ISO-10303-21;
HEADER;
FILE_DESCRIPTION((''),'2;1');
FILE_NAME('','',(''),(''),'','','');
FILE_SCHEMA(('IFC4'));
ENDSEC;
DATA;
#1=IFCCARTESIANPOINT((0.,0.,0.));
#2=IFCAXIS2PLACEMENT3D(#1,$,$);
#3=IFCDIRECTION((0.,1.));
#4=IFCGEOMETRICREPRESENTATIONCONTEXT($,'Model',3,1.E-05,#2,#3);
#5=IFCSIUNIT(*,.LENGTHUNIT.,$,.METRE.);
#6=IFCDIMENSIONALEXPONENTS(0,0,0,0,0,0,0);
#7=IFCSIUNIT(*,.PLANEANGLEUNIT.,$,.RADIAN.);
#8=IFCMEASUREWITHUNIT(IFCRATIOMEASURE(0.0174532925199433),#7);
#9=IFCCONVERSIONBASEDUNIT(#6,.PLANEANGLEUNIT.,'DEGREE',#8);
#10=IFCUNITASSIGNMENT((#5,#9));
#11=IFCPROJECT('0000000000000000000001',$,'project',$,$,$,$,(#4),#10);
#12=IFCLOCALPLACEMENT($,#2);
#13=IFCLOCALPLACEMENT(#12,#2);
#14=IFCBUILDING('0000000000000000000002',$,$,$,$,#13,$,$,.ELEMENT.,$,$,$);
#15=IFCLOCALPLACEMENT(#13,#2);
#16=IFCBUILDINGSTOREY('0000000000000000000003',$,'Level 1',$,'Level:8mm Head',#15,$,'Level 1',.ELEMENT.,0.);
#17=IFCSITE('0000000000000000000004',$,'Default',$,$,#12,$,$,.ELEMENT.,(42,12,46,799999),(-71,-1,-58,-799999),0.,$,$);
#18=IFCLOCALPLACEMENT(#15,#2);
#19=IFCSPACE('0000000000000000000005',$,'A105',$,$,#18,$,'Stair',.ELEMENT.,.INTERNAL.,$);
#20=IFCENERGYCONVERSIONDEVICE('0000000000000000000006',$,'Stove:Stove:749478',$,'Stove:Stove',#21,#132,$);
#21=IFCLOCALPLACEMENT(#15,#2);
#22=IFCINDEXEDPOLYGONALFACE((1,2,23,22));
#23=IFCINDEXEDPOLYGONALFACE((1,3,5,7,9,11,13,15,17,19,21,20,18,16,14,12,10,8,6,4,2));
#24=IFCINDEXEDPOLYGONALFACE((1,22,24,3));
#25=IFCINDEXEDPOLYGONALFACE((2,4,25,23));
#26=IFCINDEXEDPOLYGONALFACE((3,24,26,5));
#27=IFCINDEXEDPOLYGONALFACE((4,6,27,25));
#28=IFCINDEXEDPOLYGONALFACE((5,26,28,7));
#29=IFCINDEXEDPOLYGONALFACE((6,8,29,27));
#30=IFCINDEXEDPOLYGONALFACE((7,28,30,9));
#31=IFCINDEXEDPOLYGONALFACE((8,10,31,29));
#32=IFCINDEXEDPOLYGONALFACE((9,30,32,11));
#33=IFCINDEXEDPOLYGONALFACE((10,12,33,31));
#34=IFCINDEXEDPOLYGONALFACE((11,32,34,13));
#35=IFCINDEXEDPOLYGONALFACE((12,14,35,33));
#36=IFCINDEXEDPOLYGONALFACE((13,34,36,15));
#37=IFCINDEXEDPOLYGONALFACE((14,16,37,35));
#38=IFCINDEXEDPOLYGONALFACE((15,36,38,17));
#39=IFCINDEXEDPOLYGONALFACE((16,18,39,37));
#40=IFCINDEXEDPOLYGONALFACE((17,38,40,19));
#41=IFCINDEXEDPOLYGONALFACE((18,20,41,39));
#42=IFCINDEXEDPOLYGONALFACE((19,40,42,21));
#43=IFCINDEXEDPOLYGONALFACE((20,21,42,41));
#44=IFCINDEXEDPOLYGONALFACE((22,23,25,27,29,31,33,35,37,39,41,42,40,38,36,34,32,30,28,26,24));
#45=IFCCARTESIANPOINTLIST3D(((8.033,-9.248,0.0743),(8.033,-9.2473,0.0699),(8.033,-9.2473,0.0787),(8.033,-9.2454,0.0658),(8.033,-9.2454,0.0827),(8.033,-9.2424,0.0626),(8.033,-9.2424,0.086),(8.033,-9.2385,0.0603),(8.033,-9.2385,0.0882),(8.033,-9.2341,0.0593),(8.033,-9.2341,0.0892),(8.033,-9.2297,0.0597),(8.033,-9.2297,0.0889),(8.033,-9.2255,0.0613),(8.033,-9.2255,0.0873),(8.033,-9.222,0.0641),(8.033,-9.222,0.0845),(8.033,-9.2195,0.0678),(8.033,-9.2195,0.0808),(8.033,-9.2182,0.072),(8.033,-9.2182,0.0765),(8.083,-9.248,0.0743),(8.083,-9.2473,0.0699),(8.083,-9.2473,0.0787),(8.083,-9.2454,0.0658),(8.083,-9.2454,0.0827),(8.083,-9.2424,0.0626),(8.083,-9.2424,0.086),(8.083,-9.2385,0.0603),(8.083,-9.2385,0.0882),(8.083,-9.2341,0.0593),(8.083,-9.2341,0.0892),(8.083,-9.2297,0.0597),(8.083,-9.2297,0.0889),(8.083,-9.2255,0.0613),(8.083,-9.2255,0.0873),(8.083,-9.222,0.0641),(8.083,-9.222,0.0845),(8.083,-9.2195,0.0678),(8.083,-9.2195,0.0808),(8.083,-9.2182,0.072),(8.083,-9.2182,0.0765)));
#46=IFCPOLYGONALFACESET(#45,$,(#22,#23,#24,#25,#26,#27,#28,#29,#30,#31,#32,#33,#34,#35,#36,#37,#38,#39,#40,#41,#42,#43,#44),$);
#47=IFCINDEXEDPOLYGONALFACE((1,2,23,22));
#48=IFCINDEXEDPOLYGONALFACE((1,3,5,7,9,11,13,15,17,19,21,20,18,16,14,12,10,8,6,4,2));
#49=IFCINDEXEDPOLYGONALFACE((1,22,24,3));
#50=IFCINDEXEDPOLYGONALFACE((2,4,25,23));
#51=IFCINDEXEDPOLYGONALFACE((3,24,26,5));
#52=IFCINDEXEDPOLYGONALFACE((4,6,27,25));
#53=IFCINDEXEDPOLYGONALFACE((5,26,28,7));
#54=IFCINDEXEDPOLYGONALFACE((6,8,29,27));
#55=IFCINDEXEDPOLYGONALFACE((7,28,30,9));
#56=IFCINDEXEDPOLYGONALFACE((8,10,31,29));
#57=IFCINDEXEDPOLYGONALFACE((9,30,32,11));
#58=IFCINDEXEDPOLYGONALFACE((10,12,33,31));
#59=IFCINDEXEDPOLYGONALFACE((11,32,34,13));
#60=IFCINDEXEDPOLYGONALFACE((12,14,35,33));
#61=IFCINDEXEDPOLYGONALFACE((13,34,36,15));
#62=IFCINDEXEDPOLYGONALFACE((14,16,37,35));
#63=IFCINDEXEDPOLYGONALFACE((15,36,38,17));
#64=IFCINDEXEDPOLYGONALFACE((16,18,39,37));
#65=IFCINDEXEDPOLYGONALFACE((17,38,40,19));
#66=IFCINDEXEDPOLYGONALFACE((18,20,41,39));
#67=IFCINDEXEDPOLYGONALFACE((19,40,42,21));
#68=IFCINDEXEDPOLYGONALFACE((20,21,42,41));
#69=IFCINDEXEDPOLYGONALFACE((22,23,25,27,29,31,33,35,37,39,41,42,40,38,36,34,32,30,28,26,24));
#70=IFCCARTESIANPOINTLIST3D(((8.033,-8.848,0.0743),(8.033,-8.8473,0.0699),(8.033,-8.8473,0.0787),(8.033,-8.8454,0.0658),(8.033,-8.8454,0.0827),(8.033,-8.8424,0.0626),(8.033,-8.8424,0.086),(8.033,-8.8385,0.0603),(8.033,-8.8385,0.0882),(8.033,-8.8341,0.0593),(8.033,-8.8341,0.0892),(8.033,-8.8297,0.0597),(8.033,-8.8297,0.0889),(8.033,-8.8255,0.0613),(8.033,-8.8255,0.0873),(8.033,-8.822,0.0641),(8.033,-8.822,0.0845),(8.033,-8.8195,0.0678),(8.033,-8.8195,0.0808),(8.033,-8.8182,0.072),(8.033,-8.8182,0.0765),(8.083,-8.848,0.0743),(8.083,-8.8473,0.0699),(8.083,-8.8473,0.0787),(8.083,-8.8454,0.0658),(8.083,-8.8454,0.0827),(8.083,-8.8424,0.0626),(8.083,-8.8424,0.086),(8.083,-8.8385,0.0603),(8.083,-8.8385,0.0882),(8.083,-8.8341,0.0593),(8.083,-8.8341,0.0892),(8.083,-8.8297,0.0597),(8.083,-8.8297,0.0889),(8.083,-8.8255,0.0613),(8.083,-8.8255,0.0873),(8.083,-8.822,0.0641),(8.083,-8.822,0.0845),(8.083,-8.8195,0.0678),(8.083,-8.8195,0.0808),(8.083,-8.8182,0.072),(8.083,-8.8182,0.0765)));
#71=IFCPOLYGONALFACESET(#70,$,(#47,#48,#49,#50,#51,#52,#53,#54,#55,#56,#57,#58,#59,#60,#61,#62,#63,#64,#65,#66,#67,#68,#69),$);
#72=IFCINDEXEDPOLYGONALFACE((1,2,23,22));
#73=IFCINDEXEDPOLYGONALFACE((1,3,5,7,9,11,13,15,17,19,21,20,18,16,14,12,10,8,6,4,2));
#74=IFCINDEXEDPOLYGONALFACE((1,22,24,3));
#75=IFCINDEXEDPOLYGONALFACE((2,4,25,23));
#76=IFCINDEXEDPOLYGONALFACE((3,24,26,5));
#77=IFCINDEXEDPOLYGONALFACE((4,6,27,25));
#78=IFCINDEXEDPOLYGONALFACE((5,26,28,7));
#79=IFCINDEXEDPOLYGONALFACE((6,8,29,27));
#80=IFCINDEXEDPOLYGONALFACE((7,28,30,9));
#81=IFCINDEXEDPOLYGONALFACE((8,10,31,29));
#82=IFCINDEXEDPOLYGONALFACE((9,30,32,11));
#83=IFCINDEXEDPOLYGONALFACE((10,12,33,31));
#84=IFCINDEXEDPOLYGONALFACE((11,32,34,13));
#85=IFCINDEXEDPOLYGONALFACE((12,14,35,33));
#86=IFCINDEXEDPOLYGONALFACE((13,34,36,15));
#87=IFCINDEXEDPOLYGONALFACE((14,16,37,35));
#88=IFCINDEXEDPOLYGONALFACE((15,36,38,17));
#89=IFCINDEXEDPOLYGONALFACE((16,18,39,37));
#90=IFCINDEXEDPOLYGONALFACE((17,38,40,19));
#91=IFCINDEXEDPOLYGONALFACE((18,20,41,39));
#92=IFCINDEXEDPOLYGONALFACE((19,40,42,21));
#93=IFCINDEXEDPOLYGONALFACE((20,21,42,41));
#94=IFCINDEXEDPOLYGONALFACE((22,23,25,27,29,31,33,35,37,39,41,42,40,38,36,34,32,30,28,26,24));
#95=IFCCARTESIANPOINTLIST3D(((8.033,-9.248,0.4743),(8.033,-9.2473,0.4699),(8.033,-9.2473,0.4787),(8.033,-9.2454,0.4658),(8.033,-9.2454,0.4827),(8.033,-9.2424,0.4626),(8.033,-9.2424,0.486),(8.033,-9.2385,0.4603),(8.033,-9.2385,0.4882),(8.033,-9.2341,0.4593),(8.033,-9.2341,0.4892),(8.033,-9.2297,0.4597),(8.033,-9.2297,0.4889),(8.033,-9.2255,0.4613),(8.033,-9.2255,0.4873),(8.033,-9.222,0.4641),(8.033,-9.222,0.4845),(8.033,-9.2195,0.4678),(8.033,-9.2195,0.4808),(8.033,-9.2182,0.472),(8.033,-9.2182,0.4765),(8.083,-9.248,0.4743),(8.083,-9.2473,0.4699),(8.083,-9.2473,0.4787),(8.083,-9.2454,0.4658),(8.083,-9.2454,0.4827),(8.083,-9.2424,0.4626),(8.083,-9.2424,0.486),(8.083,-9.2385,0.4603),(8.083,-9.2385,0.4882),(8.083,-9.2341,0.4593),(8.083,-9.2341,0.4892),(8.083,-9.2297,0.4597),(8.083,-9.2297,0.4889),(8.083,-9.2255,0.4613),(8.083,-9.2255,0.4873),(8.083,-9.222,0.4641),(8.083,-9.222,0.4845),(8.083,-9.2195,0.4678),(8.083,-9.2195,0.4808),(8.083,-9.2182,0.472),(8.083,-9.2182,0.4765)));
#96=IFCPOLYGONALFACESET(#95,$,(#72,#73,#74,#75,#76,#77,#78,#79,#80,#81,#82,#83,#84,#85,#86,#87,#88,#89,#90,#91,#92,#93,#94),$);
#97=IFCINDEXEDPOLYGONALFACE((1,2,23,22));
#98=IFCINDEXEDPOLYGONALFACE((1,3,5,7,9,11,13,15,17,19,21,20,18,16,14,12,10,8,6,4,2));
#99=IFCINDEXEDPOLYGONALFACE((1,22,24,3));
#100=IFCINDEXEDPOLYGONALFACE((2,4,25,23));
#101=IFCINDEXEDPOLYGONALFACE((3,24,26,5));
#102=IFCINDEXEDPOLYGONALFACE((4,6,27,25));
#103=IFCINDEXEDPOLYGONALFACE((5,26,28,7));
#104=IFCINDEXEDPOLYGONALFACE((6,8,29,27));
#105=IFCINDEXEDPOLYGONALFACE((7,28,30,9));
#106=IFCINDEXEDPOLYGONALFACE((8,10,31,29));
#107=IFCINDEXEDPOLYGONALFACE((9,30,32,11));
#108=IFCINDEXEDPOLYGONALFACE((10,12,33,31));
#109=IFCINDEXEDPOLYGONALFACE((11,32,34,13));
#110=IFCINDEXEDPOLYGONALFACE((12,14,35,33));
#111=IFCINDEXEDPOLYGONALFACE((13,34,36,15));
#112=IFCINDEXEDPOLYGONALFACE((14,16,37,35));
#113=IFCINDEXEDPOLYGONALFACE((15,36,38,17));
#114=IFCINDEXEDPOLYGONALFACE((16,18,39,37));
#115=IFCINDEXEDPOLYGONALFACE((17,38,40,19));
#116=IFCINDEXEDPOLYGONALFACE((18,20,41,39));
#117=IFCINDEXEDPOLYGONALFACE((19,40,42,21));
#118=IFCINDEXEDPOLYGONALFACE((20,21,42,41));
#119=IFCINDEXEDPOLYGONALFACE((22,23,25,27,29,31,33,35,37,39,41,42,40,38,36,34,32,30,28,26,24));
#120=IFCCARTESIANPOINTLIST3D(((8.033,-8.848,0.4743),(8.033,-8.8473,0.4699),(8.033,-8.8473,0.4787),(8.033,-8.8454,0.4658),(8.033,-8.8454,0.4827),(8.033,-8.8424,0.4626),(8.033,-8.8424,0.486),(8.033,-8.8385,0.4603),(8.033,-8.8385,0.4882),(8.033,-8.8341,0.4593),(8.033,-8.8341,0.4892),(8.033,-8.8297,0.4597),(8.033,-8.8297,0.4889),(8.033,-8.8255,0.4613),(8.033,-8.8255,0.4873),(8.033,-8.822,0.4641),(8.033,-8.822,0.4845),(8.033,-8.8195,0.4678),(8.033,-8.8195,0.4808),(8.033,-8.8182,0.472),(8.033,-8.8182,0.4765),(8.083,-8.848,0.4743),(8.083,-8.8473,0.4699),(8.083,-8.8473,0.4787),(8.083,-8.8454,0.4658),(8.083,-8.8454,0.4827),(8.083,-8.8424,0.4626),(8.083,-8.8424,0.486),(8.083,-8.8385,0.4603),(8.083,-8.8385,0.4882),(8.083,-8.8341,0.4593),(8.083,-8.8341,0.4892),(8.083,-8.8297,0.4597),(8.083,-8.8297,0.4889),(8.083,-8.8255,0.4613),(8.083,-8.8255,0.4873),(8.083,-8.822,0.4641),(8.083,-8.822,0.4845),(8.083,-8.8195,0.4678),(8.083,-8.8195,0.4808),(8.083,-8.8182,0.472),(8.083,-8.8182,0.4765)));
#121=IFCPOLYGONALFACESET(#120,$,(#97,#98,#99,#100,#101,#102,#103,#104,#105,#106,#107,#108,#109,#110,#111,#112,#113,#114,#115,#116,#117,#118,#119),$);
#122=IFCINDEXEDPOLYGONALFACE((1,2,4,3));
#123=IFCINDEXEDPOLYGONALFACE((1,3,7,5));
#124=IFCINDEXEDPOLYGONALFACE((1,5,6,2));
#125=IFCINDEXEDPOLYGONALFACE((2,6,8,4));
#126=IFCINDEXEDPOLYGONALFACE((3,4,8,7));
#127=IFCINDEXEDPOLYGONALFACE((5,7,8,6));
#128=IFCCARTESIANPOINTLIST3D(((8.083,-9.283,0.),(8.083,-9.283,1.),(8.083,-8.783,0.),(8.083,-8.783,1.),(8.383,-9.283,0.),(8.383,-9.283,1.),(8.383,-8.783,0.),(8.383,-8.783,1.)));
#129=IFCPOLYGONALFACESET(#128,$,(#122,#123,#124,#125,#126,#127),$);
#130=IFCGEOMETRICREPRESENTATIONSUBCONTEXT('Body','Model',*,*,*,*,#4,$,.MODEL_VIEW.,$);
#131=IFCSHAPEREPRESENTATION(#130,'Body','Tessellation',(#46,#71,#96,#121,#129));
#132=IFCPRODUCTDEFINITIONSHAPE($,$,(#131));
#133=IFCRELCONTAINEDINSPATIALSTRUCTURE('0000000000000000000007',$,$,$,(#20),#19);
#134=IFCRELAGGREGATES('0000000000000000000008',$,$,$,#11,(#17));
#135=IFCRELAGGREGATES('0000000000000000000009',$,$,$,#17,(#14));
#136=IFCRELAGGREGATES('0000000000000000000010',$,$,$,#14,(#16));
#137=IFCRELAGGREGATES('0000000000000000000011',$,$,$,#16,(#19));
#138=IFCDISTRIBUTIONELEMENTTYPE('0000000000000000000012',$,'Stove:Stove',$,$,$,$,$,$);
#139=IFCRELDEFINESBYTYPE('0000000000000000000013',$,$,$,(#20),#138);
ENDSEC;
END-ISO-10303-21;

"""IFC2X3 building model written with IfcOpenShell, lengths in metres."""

from ifc_helpers import new_model, entity, si_unit, converted_unit, direction, frame, frame_2d, origin, origin_2d_with_axis, place, context, subcontext, project, spatial, rectangle, circle, extrude, source, transform, mapped, type_object, type_shapes, element, save


model = new_model("IFC2X3")

# Units and contexts
model_context = context("Model", 3, precision=1e-05, world=origin(), true_north=direction((0.0, 1.0)))
body_context = subcontext(model_context, "Body", "Model", "MODEL_VIEW")
ifc_project = project(units=[si_unit("LENGTHUNIT", "METRE"), converted_unit("PLANEANGLEUNIT", "DEGREE", entity("IfcRatioMeasure", 0.0174532925199433), si_unit("PLANEANGLEUNIT", "RADIAN"), dimensions=[0, 0, 0, 0, 0, 0, 0])], contexts=[model_context])

# Site, building, storey
site_placement = place(None, origin())
site = spatial("IfcSite", under=ifc_project, at=site_placement, Name="Default", CompositionType="ELEMENT", RefLatitude=(42, 12, 46, 799999), RefLongitude=(-71, -1, -58, -799999), RefElevation=0.0)
building_placement = place(site_placement, origin())
building = spatial("IfcBuilding", under=site, at=building_placement, CompositionType="ELEMENT")
storey_placement = place(building_placement, origin())
storey = spatial("IfcBuildingStorey", under=building, at=storey_placement, Name="Level 1", ObjectType="Level:8mm Head", LongName="Level 1", CompositionType="ELEMENT", Elevation=0.0)

# Shared definitions
space_1_placement = place(storey_placement, origin())
space_1 = spatial("IfcSpace", under=storey, at=space_1_placement, Name="A105", LongName="Stair", CompositionType="ELEMENT", InteriorOrExteriorSpace="INTERNAL")

# Energy conversion device
distribution_element_type_1 = type_object("IfcDistributionElementType", Name="Stove:Stove")
shared_shape_1 = source(origin(), body_context, "Body", "SweptSolid", [
    extrude(circle(Radius=0.015, at=frame_2d((0.0, 0.0), x_axis=(1.0, 0.0))), frame((0.2, -0.2, 0.0743), z_axis=(0.0, 1.0, 0.0), x_axis=(1.0, 0.0, 0.0)), (0.0, 0.0, 1.0), 0.05),
    extrude(circle(Radius=0.015, at=frame_2d((0.0, 0.0), x_axis=(1.0, 0.0))), frame((-0.2, -0.2, 0.0743), z_axis=(0.0, 1.0, 0.0), x_axis=(1.0, 0.0, 0.0)), (0.0, 0.0, 1.0), 0.05),
    extrude(circle(Radius=0.015, at=origin_2d_with_axis()), frame((0.2, -0.2, 0.4743), z_axis=(0.0, 1.0, 0.0), x_axis=(1.0, 0.0, 0.0)), (0.0, 0.0, 1.0), 0.05),
    extrude(circle(Radius=0.015, at=origin_2d_with_axis()), frame((-0.2, -0.2, 0.4743), z_axis=(0.0, 1.0, 0.0), x_axis=(1.0, 0.0, 0.0)), (0.0, 0.0, 1.0), 0.05),
    extrude(rectangle(XDim=0.5, YDim=0.3, at=origin_2d_with_axis()), frame((0.0, 0.0, 0.0), z_axis=(0.0, 0.0, 1.0), x_axis=(-1.0, 0.0, 0.0)), (0.0, 0.0, 1.0), 1.0),
])
type_shapes(distribution_element_type_1, [shared_shape_1])
energy_conversion_device_1_placement = place(space_1_placement, frame((8.233, -9.033, 0.0), z_axis=(0.0, 0.0, 1.0), x_axis=(0.0, -1.0, 0.0)))
element("IfcEnergyConversionDevice", 1, at=energy_conversion_device_1_placement, inside=space_1, type_object=distribution_element_type_1, Name="Stove:Stove:749478", ObjectType="Stove:Stove", context=body_context, shape_type="MappedRepresentation", body=[
    mapped(shared_shape_1, transform((0.0, 0.0, 0.0), scale=1.0)),
])

save(model, "model.ifc")
